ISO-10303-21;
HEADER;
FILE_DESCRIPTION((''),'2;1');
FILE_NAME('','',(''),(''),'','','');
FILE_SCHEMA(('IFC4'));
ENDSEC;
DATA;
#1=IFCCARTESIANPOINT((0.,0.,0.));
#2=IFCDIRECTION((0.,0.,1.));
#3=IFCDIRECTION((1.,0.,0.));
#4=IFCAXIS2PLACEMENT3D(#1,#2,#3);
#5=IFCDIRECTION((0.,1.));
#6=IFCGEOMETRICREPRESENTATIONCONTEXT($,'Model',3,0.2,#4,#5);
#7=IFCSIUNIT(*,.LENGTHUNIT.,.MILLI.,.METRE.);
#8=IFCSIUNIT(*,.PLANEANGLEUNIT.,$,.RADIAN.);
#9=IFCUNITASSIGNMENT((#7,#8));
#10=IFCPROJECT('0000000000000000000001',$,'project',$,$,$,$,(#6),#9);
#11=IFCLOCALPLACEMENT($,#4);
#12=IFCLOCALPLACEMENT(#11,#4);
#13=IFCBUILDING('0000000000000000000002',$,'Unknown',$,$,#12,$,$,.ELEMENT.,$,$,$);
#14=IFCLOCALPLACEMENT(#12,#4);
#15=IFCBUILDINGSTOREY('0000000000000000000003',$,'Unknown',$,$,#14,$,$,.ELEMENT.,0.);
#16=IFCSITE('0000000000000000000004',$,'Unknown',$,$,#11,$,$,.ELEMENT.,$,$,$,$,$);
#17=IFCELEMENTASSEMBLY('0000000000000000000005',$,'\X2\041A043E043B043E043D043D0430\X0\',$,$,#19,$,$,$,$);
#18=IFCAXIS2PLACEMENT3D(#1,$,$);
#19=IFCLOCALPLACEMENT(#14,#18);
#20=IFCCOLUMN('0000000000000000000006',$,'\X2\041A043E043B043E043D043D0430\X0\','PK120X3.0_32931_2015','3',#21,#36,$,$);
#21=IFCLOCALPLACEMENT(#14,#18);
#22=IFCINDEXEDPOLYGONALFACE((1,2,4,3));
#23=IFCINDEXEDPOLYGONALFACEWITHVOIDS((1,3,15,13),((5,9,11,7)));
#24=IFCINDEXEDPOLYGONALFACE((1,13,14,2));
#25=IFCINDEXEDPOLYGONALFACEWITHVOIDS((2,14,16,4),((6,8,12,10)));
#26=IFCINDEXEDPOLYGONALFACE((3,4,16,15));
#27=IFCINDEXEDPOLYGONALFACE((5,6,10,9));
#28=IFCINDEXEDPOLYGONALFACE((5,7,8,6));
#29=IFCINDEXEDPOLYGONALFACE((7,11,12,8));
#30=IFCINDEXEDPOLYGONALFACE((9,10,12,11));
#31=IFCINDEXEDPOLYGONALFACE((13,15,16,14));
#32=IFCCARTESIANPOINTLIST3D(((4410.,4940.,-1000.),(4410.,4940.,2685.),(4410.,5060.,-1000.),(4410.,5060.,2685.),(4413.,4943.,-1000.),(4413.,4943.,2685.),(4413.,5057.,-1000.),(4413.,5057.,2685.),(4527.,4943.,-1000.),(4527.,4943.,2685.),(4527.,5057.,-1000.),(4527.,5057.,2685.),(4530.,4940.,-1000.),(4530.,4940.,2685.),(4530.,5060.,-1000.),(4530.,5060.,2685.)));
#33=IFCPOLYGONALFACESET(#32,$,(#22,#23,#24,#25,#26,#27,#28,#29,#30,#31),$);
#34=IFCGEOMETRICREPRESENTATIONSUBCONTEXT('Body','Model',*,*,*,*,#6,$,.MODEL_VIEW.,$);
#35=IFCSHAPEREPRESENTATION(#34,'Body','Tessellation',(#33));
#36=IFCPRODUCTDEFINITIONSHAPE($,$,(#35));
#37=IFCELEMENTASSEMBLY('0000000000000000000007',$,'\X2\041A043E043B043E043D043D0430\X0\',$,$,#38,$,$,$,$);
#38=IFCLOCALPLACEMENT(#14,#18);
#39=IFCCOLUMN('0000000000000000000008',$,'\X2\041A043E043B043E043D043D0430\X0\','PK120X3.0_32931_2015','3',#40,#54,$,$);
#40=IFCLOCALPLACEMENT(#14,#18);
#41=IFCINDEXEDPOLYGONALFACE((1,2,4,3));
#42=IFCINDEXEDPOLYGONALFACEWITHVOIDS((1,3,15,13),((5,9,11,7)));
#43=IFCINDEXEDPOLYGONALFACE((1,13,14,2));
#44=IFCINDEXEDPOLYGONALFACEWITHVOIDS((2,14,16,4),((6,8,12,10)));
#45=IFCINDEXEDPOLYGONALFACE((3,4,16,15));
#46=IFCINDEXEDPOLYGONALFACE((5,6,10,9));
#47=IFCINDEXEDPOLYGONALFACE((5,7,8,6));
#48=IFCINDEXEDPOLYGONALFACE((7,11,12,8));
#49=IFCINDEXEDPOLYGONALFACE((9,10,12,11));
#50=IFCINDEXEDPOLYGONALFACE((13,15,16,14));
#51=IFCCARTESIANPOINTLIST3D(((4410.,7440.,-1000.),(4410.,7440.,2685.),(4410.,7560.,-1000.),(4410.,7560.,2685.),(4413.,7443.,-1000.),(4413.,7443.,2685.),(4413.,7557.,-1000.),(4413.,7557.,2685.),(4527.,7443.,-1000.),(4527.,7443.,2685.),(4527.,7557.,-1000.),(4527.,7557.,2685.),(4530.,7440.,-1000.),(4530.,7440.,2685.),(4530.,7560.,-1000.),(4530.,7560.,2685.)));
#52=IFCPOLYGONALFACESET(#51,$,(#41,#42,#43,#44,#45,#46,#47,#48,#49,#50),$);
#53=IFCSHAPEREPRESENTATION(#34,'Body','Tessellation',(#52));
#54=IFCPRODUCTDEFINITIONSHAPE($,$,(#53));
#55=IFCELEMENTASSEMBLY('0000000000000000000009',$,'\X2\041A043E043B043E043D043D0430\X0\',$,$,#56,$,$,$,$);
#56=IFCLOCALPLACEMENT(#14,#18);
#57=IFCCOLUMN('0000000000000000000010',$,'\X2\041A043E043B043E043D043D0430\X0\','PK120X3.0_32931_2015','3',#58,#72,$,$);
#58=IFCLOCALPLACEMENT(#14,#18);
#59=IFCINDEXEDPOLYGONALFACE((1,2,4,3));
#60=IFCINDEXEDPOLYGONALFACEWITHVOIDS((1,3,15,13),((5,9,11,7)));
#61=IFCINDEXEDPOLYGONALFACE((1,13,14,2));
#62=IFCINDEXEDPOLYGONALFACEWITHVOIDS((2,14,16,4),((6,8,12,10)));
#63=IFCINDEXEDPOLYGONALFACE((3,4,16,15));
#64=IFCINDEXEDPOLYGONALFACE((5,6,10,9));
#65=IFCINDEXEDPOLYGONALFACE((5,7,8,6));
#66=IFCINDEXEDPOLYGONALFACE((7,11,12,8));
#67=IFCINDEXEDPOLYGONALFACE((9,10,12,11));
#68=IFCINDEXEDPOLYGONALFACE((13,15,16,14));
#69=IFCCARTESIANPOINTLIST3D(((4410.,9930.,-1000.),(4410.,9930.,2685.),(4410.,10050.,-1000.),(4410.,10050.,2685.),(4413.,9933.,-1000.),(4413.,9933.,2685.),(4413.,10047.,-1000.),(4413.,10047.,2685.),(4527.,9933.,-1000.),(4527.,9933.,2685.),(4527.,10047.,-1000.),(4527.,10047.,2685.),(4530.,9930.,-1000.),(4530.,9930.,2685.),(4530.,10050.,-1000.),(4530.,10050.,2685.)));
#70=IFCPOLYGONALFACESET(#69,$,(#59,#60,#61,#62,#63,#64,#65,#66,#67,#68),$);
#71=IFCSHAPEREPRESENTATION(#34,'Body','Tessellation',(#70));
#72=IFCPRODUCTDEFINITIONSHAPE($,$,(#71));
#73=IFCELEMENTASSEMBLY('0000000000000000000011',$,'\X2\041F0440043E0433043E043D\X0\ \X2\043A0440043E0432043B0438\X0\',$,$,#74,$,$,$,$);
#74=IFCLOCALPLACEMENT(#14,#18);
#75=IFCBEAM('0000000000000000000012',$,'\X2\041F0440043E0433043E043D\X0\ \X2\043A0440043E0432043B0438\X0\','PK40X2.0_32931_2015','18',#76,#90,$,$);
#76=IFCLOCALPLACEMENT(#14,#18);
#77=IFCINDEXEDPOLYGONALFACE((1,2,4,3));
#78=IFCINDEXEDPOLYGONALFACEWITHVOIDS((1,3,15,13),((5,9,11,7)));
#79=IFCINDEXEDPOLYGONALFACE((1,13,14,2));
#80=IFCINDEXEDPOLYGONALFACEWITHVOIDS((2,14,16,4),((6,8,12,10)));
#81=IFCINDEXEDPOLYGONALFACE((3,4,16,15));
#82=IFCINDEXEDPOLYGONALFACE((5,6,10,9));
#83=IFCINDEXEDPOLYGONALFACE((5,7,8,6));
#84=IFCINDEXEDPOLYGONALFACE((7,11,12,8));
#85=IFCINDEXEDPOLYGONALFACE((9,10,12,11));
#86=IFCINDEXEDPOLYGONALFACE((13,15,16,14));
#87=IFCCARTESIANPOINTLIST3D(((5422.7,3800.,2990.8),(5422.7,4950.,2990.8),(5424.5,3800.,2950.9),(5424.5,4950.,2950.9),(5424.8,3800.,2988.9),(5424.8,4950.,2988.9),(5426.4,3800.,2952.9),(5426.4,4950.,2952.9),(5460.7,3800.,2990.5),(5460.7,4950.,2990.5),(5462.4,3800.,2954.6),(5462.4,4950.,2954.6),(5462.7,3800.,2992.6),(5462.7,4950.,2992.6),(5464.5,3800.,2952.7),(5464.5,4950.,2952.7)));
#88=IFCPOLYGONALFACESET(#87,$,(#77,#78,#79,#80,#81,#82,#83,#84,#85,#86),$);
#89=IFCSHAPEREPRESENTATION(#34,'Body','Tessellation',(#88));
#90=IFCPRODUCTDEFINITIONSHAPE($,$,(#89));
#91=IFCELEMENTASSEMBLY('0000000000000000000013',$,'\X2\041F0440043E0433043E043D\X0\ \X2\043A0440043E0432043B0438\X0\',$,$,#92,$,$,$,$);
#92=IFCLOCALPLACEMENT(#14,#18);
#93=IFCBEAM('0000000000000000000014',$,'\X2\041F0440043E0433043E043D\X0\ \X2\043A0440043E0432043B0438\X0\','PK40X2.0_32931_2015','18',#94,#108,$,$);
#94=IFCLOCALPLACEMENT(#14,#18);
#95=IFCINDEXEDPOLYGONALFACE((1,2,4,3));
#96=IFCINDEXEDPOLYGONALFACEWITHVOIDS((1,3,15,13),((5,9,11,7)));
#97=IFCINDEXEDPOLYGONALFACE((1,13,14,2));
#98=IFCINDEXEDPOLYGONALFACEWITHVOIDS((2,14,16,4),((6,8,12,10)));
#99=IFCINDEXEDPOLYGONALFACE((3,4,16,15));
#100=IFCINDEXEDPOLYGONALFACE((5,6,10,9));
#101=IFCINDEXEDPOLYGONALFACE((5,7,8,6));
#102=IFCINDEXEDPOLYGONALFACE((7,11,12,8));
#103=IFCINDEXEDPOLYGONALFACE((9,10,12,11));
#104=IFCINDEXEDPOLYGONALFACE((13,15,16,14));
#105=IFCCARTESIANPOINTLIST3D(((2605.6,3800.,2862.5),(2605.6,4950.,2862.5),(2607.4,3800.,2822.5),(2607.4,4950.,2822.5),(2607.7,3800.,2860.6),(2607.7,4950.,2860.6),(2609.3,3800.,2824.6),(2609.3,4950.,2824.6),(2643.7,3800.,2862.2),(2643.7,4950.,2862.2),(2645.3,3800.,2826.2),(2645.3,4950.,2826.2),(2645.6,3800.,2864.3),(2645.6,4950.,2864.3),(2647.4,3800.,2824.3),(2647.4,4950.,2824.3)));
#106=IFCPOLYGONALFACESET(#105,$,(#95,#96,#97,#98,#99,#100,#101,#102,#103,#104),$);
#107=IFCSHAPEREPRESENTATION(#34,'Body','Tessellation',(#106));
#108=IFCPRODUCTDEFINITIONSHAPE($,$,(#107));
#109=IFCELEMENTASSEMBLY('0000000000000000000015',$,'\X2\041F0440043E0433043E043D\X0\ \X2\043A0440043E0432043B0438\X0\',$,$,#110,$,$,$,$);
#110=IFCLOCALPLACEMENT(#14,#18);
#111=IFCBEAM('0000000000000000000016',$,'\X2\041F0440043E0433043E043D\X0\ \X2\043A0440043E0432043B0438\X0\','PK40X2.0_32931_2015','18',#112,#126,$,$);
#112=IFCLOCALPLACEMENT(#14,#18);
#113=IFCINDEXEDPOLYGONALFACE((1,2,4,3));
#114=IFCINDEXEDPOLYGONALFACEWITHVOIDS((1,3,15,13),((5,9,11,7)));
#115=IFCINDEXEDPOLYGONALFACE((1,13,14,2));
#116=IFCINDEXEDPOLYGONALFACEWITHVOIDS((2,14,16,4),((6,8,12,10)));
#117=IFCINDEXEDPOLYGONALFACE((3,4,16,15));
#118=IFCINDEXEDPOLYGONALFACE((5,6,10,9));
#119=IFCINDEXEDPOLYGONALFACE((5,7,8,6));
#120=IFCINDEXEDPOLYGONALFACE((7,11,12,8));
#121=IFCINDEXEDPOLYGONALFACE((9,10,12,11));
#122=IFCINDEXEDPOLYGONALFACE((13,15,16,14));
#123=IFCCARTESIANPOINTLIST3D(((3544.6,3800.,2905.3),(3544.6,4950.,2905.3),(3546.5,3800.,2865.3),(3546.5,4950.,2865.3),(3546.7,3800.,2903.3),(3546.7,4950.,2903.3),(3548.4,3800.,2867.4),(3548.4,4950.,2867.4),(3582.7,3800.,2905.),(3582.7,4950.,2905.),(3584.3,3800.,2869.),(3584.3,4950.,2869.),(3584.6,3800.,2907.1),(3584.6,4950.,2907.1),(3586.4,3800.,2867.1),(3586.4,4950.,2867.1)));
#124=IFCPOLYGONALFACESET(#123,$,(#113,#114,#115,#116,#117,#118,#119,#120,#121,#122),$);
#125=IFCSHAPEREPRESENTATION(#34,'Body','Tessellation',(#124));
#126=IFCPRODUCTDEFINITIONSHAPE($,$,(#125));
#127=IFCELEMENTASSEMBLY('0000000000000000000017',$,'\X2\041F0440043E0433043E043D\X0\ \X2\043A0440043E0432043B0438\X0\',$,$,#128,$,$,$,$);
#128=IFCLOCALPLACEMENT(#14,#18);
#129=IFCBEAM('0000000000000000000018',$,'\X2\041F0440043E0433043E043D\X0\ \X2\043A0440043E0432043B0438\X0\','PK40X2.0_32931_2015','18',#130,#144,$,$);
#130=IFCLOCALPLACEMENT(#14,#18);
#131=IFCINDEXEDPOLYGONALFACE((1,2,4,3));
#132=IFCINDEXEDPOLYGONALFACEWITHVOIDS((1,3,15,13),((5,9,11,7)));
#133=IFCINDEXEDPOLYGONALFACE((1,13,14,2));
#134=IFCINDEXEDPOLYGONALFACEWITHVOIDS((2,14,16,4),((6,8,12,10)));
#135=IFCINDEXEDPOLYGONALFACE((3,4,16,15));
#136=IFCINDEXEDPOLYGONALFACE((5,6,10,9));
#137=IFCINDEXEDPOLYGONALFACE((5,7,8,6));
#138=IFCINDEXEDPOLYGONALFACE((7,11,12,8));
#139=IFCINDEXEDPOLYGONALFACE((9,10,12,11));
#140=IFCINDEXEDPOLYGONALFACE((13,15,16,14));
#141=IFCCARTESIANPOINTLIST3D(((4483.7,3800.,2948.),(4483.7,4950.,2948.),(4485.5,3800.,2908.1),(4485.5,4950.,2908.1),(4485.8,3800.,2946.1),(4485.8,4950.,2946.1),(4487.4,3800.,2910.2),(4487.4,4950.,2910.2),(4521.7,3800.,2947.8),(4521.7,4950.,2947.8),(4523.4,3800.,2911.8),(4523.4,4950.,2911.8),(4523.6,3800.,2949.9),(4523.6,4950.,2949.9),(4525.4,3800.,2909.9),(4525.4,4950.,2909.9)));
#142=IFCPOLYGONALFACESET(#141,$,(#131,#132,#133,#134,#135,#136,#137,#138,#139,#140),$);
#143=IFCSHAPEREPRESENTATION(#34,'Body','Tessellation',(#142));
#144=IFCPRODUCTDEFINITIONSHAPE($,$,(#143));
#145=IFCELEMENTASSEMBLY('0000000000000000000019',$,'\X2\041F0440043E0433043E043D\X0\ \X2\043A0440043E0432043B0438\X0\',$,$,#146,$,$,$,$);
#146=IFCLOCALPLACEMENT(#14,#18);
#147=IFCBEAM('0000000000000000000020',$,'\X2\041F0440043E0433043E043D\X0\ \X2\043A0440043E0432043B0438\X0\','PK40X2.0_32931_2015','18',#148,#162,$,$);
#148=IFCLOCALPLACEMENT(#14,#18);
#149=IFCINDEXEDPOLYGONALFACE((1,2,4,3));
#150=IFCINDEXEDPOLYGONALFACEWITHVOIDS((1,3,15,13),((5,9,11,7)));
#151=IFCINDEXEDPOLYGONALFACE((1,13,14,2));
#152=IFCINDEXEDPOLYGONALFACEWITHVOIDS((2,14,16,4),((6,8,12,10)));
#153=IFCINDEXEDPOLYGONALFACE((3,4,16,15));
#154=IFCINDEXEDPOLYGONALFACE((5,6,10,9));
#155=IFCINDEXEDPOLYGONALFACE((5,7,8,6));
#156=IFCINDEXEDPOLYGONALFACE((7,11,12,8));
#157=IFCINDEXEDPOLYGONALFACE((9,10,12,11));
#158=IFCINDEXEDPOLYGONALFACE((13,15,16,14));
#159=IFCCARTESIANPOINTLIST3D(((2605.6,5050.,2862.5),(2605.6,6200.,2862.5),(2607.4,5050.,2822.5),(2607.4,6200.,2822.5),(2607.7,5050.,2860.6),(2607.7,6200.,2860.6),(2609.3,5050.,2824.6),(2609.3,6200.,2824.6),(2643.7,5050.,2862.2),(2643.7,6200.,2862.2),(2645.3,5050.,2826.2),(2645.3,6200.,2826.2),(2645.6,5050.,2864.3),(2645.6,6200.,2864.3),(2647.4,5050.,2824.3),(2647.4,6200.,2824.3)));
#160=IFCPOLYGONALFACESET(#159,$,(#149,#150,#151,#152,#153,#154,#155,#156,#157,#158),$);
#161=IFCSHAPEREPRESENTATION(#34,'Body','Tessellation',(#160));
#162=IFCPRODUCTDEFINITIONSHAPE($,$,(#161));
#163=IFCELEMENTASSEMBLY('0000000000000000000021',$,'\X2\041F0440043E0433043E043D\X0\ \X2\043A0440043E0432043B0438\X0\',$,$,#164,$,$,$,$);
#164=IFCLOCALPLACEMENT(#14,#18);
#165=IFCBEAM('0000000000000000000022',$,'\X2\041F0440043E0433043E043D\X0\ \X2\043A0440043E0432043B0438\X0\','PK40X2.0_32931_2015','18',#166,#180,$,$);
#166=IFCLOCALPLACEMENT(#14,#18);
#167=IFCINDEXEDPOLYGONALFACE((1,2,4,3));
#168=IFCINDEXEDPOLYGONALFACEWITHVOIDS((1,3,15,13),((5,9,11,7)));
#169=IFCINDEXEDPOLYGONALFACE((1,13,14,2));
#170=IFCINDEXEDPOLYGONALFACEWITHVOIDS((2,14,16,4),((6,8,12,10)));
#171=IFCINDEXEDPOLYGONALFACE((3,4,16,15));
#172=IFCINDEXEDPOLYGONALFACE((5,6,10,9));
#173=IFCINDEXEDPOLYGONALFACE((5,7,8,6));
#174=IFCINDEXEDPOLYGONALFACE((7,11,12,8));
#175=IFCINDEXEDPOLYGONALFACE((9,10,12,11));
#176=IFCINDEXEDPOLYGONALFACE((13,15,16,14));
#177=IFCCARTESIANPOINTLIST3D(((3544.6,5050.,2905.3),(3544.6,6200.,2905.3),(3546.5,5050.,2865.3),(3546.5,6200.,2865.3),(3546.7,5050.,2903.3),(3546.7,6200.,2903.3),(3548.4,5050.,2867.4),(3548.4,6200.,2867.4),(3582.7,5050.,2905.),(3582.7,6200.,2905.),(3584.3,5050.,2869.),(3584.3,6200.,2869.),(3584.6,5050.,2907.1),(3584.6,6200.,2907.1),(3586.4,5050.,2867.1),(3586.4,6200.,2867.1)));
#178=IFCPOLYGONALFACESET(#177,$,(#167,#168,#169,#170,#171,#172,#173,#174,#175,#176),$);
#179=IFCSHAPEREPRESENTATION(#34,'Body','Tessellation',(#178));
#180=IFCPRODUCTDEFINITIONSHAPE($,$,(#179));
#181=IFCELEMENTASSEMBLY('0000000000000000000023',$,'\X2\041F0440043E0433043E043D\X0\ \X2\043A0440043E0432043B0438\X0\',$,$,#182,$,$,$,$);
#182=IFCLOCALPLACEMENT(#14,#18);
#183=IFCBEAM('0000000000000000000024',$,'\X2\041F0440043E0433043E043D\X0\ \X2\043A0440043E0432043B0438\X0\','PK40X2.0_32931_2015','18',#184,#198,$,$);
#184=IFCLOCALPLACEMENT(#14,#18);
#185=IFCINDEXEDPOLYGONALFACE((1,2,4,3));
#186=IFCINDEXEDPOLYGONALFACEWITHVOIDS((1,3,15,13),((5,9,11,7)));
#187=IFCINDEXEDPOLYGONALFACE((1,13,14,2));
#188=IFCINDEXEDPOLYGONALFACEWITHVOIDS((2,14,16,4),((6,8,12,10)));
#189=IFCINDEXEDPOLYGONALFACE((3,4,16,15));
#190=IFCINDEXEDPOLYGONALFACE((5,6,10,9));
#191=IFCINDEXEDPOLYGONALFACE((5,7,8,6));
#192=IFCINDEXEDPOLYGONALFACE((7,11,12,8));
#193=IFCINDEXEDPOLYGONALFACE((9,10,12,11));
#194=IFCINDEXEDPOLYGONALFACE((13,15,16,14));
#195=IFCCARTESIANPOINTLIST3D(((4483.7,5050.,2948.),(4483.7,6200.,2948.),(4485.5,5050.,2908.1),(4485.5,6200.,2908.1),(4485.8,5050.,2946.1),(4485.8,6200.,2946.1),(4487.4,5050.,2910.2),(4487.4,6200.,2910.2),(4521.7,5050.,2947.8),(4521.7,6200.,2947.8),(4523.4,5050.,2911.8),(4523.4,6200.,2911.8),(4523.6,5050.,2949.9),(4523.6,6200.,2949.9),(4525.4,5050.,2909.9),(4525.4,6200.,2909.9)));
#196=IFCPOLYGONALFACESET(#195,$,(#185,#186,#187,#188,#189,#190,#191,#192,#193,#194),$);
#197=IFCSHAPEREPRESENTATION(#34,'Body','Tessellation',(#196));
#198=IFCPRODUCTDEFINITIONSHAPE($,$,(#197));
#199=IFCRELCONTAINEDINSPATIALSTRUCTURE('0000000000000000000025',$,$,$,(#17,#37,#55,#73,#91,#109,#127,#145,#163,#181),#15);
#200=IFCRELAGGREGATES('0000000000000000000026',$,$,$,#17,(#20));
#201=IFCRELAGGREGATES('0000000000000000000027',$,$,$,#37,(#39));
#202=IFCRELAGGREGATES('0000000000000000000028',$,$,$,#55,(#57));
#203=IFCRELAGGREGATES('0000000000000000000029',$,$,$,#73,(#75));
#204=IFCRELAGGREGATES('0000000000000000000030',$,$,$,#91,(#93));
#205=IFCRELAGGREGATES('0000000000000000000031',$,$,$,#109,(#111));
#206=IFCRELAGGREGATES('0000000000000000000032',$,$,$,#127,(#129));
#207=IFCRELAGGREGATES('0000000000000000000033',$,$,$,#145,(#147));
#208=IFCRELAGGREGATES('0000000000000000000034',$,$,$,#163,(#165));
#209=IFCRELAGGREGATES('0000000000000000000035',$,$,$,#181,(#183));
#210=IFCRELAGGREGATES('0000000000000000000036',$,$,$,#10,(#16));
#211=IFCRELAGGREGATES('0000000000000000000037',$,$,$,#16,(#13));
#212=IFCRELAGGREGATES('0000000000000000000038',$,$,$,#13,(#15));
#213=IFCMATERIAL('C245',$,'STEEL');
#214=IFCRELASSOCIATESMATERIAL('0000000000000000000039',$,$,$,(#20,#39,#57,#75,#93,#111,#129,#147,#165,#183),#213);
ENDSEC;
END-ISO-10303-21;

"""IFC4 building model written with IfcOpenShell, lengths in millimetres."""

from ifc_helpers import new_model, si_unit, direction, frame, origin_with_axes, place, context, subcontext, project, spatial, line, indexed_curve, outline, extrude, material, element, aggregate, save


model = new_model("IFC4")

# Units and contexts
model_context = context("Model", 3, precision=0.2, world=origin_with_axes(), true_north=direction((0.0, 1.0)))
body_context = subcontext(model_context, "Body", "Model", "MODEL_VIEW")
ifc_project = project(units=[si_unit("LENGTHUNIT", "METRE", prefix="MILLI"), si_unit("PLANEANGLEUNIT", "RADIAN")], contexts=[model_context])

# Site, building, storey
site_placement = place(None, origin_with_axes())
site = spatial("IfcSite", under=ifc_project, at=site_placement, Name="Unknown", CompositionType="ELEMENT")
building_placement = place(site_placement, origin_with_axes())
building = spatial("IfcBuilding", under=site, at=building_placement, Name="Unknown", CompositionType="ELEMENT")
storey_placement = place(building_placement, origin_with_axes())
storey = spatial("IfcBuildingStorey", under=building, at=storey_placement, Name="Unknown", CompositionType="ELEMENT", Elevation=0.0)

# Shared definitions
placement_1 = place(storey_placement, frame((4470.0, 5000.0, -1000.0), z_axis=(-1.0, 0.0, 0.0), x_axis=(0.0, 0.0, 1.0)))
placement_2 = place(placement_1, origin_with_axes())
placement_3 = place(storey_placement, frame((4470.0, 7500.0, -1000.0), z_axis=(-1.0, 0.0, 0.0), x_axis=(0.0, 0.0, 1.0)))
placement_4 = place(placement_3, origin_with_axes())

# Shared definitions
ifc_material_1 = material(Name="C245", Category="STEEL")

# Element assemblies, columns
assembly_1 = element("IfcElementAssembly", 1, at=placement_1, inside=storey, Name="Колонна")
column_1 = element("IfcColumn", 2, at=placement_2, material=ifc_material_1, Name="Колонна", Description="PK120X3.0_32931_2015", ObjectType="3", context=body_context, shape_type="SolidModel", body=[
    extrude(outline(indexed_curve([(-60.0, -60.0), (60.0, -60.0), (60.0, 60.0), (-60.0, 60.0)], segments=[line(1, 2, 3, 4, 1)]), holes=[indexed_curve([(-57.0, -57.0), (-57.0, 57.0), (57.0, 57.0), (57.0, -57.0)], segments=[line(1, 2, 3, 4, 1)])]), frame((0.0, 0.0, 0.0), z_axis=(-1.0, 0.0, 0.0), x_axis=(0.0, 0.0, 1.0)), (0.0, 0.0, -1.0), 3685.0),
])
aggregate(assembly_1, [column_1])
assembly_2 = element("IfcElementAssembly", 3, at=placement_3, inside=storey, Name="Колонна")
column_2 = element("IfcColumn", 4, at=placement_4, material=ifc_material_1, Name="Колонна", Description="PK120X3.0_32931_2015", ObjectType="3", context=body_context, shape_type="SolidModel", body=[
    extrude(outline(indexed_curve([(-60.0, -60.0), (60.0, -60.0), (60.0, 60.0), (-60.0, 60.0)], segments=[line(1, 2, 3, 4, 1)]), holes=[indexed_curve([(-57.0, -57.0), (-57.0, 57.0), (57.0, 57.0), (57.0, -57.0)], segments=[line(1, 2, 3, 4, 1)])]), frame((0.0, 0.0, 0.0), z_axis=(-1.0, 0.0, 0.0), x_axis=(0.0, 0.0, 1.0)), (0.0, 0.0, -1.0), 3685.0),
])
aggregate(assembly_2, [column_2])
assembly_3_placement = place(storey_placement, frame((4470.0, 9990.0, -1000.0), z_axis=(-1.0, 0.0, 0.0), x_axis=(0.0, 0.0, 1.0)))
assembly_3 = element("IfcElementAssembly", 5, at=assembly_3_placement, inside=storey, Name="Колонна")
column_3_placement = place(assembly_3_placement, origin_with_axes())
column_3 = element("IfcColumn", 6, at=column_3_placement, material=ifc_material_1, Name="Колонна", Description="PK120X3.0_32931_2015", ObjectType="3", context=body_context, shape_type="SolidModel", body=[
    extrude(outline(indexed_curve([(-60.0, -60.0), (60.0, -60.0), (60.0, 60.0), (-60.0, 60.0)], segments=[line(1, 2, 3, 4, 1)]), holes=[indexed_curve([(-57.0, -57.0), (-57.0, 57.0), (57.0, 57.0), (57.0, -57.0)], segments=[line(1, 2, 3, 4, 1)])]), frame((0.0, 0.0, 0.0), z_axis=(-1.0, 0.0, 0.0), x_axis=(0.0, 0.0, 1.0)), (0.0, 0.0, -1.0), 3685.0),
])
aggregate(assembly_3, [column_3])

# Element assemblies, beams
assembly_4_placement = place(storey_placement, frame((5443.6, 4950.0, 2971.7), z_axis=(-0.998964, 0.0, -0.045508), x_axis=(0.0, -1.0, 0.0)))
assembly_4 = element("IfcElementAssembly", 7, at=assembly_4_placement, inside=storey, Name="Прогон кровли")
beam_1_placement = place(assembly_4_placement, origin_with_axes())
beam_1 = element("IfcBeam", 8, at=beam_1_placement, material=ifc_material_1, Name="Прогон кровли", Description="PK40X2.0_32931_2015", ObjectType="18", context=body_context, shape_type="SolidModel", body=[
    extrude(outline(indexed_curve([(-20.0, -20.0), (20.0, -20.0), (20.0, 20.0), (-20.0, 20.0)], segments=[line(1, 2, 3, 4, 1)]), holes=[indexed_curve([(-18.0, -18.0), (-18.0, 18.0), (18.0, 18.0), (18.0, -18.0)], segments=[line(1, 2, 3, 4, 1)])]), frame((0.0, 0.0, 0.0), z_axis=(-1.0, 0.0, 0.0), x_axis=(0.0, 0.0, 1.0)), (0.0, 0.0, -1.0), 1150.0),
])
aggregate(assembly_4, [beam_1])
assembly_5_placement = place(storey_placement, frame((2626.5, 4950.0, 2843.4), z_axis=(-0.998964, 0.0, -0.045508), x_axis=(0.0, -1.0, 0.0)))
assembly_5 = element("IfcElementAssembly", 9, at=assembly_5_placement, inside=storey, Name="Прогон кровли")
beam_2_placement = place(assembly_5_placement, origin_with_axes())
beam_2 = element("IfcBeam", 10, at=beam_2_placement, material=ifc_material_1, Name="Прогон кровли", Description="PK40X2.0_32931_2015", ObjectType="18", context=body_context, shape_type="SolidModel", body=[
    extrude(outline(indexed_curve([(-20.0, -20.0), (20.0, -20.0), (20.0, 20.0), (-20.0, 20.0)], segments=[line(1, 2, 3, 4, 1)]), holes=[indexed_curve([(-18.0, -18.0), (-18.0, 18.0), (18.0, 18.0), (18.0, -18.0)], segments=[line(1, 2, 3, 4, 1)])]), frame((0.0, 0.0, 0.0), z_axis=(-1.0, 0.0, 0.0), x_axis=(0.0, 0.0, 1.0)), (0.0, 0.0, -1.0), 1150.0),
])
aggregate(assembly_5, [beam_2])
assembly_6_placement = place(storey_placement, frame((3565.5, 4950.0, 2886.2), z_axis=(-0.998964, 0.0, -0.045508), x_axis=(0.0, -1.0, 0.0)))
assembly_6 = element("IfcElementAssembly", 11, at=assembly_6_placement, inside=storey, Name="Прогон кровли")
beam_3_placement = place(assembly_6_placement, origin_with_axes())
beam_3 = element("IfcBeam", 12, at=beam_3_placement, material=ifc_material_1, Name="Прогон кровли", Description="PK40X2.0_32931_2015", ObjectType="18", context=body_context, shape_type="SolidModel", body=[
    extrude(outline(indexed_curve([(-20.0, -20.0), (20.0, -20.0), (20.0, 20.0), (-20.0, 20.0)], segments=[line(1, 2, 3, 4, 1)]), holes=[indexed_curve([(-18.0, -18.0), (-18.0, 18.0), (18.0, 18.0), (18.0, -18.0)], segments=[line(1, 2, 3, 4, 1)])]), frame((0.0, 0.0, 0.0), z_axis=(-1.0, 0.0, 0.0), x_axis=(0.0, 0.0, 1.0)), (0.0, 0.0, -1.0), 1150.0),
])
aggregate(assembly_6, [beam_3])
assembly_7_placement = place(storey_placement, frame((4504.6, 4950.0, 2929.0), z_axis=(-0.998964, 0.0, -0.045508), x_axis=(0.0, -1.0, 0.0)))
assembly_7 = element("IfcElementAssembly", 13, at=assembly_7_placement, inside=storey, Name="Прогон кровли")
beam_4_placement = place(assembly_7_placement, origin_with_axes())
beam_4 = element("IfcBeam", 14, at=beam_4_placement, material=ifc_material_1, Name="Прогон кровли", Description="PK40X2.0_32931_2015", ObjectType="18", context=body_context, shape_type="SolidModel", body=[
    extrude(outline(indexed_curve([(-20.0, -20.0), (20.0, -20.0), (20.0, 20.0), (-20.0, 20.0)], segments=[line(1, 2, 3, 4, 1)]), holes=[indexed_curve([(-18.0, -18.0), (-18.0, 18.0), (18.0, 18.0), (18.0, -18.0)], segments=[line(1, 2, 3, 4, 1)])]), frame((0.0, 0.0, 0.0), z_axis=(-1.0, 0.0, 0.0), x_axis=(0.0, 0.0, 1.0)), (0.0, 0.0, -1.0), 1150.0),
])
aggregate(assembly_7, [beam_4])
assembly_8_placement = place(storey_placement, frame((2626.5, 6200.0, 2843.4), z_axis=(-0.998964, 0.0, -0.045508), x_axis=(0.0, -1.0, 0.0)))
assembly_8 = element("IfcElementAssembly", 15, at=assembly_8_placement, inside=storey, Name="Прогон кровли")
beam_5_placement = place(assembly_8_placement, origin_with_axes())
beam_5 = element("IfcBeam", 16, at=beam_5_placement, material=ifc_material_1, Name="Прогон кровли", Description="PK40X2.0_32931_2015", ObjectType="18", context=body_context, shape_type="SolidModel", body=[
    extrude(outline(indexed_curve([(-20.0, -20.0), (20.0, -20.0), (20.0, 20.0), (-20.0, 20.0)], segments=[line(1, 2, 3, 4, 1)]), holes=[indexed_curve([(-18.0, -18.0), (-18.0, 18.0), (18.0, 18.0), (18.0, -18.0)], segments=[line(1, 2, 3, 4, 1)])]), frame((0.0, 0.0, 0.0), z_axis=(-1.0, 0.0, 0.0), x_axis=(0.0, 0.0, 1.0)), (0.0, 0.0, -1.0), 1150.0),
])
aggregate(assembly_8, [beam_5])
assembly_9_placement = place(storey_placement, frame((3565.5, 6200.0, 2886.2), z_axis=(-0.998964, 0.0, -0.045508), x_axis=(0.0, -1.0, 0.0)))
assembly_9 = element("IfcElementAssembly", 17, at=assembly_9_placement, inside=storey, Name="Прогон кровли")
beam_6_placement = place(assembly_9_placement, origin_with_axes())
beam_6 = element("IfcBeam", 18, at=beam_6_placement, material=ifc_material_1, Name="Прогон кровли", Description="PK40X2.0_32931_2015", ObjectType="18", context=body_context, shape_type="SolidModel", body=[
    extrude(outline(indexed_curve([(-20.0, -20.0), (20.0, -20.0), (20.0, 20.0), (-20.0, 20.0)], segments=[line(1, 2, 3, 4, 1)]), holes=[indexed_curve([(-18.0, -18.0), (-18.0, 18.0), (18.0, 18.0), (18.0, -18.0)], segments=[line(1, 2, 3, 4, 1)])]), frame((0.0, 0.0, 0.0), z_axis=(-1.0, 0.0, 0.0), x_axis=(0.0, 0.0, 1.0)), (0.0, 0.0, -1.0), 1150.0),
])
aggregate(assembly_9, [beam_6])
assembly_10_placement = place(storey_placement, frame((4504.6, 6200.0, 2929.0), z_axis=(-0.998964, 0.0, -0.045508), x_axis=(0.0, -1.0, 0.0)))
assembly_10 = element("IfcElementAssembly", 19, at=assembly_10_placement, inside=storey, Name="Прогон кровли")
beam_7_placement = place(assembly_10_placement, origin_with_axes())
beam_7 = element("IfcBeam", 20, at=beam_7_placement, material=ifc_material_1, Name="Прогон кровли", Description="PK40X2.0_32931_2015", ObjectType="18", context=body_context, shape_type="SolidModel", body=[
    extrude(outline(indexed_curve([(-20.0, -20.0), (20.0, -20.0), (20.0, 20.0), (-20.0, 20.0)], segments=[line(1, 2, 3, 4, 1)]), holes=[indexed_curve([(-18.0, -18.0), (-18.0, 18.0), (18.0, 18.0), (18.0, -18.0)], segments=[line(1, 2, 3, 4, 1)])]), frame((0.0, 0.0, 0.0), z_axis=(-1.0, 0.0, 0.0), x_axis=(0.0, 0.0, 1.0)), (0.0, 0.0, -1.0), 1150.0),
])
aggregate(assembly_10, [beam_7])

save(model, "model.ifc")
